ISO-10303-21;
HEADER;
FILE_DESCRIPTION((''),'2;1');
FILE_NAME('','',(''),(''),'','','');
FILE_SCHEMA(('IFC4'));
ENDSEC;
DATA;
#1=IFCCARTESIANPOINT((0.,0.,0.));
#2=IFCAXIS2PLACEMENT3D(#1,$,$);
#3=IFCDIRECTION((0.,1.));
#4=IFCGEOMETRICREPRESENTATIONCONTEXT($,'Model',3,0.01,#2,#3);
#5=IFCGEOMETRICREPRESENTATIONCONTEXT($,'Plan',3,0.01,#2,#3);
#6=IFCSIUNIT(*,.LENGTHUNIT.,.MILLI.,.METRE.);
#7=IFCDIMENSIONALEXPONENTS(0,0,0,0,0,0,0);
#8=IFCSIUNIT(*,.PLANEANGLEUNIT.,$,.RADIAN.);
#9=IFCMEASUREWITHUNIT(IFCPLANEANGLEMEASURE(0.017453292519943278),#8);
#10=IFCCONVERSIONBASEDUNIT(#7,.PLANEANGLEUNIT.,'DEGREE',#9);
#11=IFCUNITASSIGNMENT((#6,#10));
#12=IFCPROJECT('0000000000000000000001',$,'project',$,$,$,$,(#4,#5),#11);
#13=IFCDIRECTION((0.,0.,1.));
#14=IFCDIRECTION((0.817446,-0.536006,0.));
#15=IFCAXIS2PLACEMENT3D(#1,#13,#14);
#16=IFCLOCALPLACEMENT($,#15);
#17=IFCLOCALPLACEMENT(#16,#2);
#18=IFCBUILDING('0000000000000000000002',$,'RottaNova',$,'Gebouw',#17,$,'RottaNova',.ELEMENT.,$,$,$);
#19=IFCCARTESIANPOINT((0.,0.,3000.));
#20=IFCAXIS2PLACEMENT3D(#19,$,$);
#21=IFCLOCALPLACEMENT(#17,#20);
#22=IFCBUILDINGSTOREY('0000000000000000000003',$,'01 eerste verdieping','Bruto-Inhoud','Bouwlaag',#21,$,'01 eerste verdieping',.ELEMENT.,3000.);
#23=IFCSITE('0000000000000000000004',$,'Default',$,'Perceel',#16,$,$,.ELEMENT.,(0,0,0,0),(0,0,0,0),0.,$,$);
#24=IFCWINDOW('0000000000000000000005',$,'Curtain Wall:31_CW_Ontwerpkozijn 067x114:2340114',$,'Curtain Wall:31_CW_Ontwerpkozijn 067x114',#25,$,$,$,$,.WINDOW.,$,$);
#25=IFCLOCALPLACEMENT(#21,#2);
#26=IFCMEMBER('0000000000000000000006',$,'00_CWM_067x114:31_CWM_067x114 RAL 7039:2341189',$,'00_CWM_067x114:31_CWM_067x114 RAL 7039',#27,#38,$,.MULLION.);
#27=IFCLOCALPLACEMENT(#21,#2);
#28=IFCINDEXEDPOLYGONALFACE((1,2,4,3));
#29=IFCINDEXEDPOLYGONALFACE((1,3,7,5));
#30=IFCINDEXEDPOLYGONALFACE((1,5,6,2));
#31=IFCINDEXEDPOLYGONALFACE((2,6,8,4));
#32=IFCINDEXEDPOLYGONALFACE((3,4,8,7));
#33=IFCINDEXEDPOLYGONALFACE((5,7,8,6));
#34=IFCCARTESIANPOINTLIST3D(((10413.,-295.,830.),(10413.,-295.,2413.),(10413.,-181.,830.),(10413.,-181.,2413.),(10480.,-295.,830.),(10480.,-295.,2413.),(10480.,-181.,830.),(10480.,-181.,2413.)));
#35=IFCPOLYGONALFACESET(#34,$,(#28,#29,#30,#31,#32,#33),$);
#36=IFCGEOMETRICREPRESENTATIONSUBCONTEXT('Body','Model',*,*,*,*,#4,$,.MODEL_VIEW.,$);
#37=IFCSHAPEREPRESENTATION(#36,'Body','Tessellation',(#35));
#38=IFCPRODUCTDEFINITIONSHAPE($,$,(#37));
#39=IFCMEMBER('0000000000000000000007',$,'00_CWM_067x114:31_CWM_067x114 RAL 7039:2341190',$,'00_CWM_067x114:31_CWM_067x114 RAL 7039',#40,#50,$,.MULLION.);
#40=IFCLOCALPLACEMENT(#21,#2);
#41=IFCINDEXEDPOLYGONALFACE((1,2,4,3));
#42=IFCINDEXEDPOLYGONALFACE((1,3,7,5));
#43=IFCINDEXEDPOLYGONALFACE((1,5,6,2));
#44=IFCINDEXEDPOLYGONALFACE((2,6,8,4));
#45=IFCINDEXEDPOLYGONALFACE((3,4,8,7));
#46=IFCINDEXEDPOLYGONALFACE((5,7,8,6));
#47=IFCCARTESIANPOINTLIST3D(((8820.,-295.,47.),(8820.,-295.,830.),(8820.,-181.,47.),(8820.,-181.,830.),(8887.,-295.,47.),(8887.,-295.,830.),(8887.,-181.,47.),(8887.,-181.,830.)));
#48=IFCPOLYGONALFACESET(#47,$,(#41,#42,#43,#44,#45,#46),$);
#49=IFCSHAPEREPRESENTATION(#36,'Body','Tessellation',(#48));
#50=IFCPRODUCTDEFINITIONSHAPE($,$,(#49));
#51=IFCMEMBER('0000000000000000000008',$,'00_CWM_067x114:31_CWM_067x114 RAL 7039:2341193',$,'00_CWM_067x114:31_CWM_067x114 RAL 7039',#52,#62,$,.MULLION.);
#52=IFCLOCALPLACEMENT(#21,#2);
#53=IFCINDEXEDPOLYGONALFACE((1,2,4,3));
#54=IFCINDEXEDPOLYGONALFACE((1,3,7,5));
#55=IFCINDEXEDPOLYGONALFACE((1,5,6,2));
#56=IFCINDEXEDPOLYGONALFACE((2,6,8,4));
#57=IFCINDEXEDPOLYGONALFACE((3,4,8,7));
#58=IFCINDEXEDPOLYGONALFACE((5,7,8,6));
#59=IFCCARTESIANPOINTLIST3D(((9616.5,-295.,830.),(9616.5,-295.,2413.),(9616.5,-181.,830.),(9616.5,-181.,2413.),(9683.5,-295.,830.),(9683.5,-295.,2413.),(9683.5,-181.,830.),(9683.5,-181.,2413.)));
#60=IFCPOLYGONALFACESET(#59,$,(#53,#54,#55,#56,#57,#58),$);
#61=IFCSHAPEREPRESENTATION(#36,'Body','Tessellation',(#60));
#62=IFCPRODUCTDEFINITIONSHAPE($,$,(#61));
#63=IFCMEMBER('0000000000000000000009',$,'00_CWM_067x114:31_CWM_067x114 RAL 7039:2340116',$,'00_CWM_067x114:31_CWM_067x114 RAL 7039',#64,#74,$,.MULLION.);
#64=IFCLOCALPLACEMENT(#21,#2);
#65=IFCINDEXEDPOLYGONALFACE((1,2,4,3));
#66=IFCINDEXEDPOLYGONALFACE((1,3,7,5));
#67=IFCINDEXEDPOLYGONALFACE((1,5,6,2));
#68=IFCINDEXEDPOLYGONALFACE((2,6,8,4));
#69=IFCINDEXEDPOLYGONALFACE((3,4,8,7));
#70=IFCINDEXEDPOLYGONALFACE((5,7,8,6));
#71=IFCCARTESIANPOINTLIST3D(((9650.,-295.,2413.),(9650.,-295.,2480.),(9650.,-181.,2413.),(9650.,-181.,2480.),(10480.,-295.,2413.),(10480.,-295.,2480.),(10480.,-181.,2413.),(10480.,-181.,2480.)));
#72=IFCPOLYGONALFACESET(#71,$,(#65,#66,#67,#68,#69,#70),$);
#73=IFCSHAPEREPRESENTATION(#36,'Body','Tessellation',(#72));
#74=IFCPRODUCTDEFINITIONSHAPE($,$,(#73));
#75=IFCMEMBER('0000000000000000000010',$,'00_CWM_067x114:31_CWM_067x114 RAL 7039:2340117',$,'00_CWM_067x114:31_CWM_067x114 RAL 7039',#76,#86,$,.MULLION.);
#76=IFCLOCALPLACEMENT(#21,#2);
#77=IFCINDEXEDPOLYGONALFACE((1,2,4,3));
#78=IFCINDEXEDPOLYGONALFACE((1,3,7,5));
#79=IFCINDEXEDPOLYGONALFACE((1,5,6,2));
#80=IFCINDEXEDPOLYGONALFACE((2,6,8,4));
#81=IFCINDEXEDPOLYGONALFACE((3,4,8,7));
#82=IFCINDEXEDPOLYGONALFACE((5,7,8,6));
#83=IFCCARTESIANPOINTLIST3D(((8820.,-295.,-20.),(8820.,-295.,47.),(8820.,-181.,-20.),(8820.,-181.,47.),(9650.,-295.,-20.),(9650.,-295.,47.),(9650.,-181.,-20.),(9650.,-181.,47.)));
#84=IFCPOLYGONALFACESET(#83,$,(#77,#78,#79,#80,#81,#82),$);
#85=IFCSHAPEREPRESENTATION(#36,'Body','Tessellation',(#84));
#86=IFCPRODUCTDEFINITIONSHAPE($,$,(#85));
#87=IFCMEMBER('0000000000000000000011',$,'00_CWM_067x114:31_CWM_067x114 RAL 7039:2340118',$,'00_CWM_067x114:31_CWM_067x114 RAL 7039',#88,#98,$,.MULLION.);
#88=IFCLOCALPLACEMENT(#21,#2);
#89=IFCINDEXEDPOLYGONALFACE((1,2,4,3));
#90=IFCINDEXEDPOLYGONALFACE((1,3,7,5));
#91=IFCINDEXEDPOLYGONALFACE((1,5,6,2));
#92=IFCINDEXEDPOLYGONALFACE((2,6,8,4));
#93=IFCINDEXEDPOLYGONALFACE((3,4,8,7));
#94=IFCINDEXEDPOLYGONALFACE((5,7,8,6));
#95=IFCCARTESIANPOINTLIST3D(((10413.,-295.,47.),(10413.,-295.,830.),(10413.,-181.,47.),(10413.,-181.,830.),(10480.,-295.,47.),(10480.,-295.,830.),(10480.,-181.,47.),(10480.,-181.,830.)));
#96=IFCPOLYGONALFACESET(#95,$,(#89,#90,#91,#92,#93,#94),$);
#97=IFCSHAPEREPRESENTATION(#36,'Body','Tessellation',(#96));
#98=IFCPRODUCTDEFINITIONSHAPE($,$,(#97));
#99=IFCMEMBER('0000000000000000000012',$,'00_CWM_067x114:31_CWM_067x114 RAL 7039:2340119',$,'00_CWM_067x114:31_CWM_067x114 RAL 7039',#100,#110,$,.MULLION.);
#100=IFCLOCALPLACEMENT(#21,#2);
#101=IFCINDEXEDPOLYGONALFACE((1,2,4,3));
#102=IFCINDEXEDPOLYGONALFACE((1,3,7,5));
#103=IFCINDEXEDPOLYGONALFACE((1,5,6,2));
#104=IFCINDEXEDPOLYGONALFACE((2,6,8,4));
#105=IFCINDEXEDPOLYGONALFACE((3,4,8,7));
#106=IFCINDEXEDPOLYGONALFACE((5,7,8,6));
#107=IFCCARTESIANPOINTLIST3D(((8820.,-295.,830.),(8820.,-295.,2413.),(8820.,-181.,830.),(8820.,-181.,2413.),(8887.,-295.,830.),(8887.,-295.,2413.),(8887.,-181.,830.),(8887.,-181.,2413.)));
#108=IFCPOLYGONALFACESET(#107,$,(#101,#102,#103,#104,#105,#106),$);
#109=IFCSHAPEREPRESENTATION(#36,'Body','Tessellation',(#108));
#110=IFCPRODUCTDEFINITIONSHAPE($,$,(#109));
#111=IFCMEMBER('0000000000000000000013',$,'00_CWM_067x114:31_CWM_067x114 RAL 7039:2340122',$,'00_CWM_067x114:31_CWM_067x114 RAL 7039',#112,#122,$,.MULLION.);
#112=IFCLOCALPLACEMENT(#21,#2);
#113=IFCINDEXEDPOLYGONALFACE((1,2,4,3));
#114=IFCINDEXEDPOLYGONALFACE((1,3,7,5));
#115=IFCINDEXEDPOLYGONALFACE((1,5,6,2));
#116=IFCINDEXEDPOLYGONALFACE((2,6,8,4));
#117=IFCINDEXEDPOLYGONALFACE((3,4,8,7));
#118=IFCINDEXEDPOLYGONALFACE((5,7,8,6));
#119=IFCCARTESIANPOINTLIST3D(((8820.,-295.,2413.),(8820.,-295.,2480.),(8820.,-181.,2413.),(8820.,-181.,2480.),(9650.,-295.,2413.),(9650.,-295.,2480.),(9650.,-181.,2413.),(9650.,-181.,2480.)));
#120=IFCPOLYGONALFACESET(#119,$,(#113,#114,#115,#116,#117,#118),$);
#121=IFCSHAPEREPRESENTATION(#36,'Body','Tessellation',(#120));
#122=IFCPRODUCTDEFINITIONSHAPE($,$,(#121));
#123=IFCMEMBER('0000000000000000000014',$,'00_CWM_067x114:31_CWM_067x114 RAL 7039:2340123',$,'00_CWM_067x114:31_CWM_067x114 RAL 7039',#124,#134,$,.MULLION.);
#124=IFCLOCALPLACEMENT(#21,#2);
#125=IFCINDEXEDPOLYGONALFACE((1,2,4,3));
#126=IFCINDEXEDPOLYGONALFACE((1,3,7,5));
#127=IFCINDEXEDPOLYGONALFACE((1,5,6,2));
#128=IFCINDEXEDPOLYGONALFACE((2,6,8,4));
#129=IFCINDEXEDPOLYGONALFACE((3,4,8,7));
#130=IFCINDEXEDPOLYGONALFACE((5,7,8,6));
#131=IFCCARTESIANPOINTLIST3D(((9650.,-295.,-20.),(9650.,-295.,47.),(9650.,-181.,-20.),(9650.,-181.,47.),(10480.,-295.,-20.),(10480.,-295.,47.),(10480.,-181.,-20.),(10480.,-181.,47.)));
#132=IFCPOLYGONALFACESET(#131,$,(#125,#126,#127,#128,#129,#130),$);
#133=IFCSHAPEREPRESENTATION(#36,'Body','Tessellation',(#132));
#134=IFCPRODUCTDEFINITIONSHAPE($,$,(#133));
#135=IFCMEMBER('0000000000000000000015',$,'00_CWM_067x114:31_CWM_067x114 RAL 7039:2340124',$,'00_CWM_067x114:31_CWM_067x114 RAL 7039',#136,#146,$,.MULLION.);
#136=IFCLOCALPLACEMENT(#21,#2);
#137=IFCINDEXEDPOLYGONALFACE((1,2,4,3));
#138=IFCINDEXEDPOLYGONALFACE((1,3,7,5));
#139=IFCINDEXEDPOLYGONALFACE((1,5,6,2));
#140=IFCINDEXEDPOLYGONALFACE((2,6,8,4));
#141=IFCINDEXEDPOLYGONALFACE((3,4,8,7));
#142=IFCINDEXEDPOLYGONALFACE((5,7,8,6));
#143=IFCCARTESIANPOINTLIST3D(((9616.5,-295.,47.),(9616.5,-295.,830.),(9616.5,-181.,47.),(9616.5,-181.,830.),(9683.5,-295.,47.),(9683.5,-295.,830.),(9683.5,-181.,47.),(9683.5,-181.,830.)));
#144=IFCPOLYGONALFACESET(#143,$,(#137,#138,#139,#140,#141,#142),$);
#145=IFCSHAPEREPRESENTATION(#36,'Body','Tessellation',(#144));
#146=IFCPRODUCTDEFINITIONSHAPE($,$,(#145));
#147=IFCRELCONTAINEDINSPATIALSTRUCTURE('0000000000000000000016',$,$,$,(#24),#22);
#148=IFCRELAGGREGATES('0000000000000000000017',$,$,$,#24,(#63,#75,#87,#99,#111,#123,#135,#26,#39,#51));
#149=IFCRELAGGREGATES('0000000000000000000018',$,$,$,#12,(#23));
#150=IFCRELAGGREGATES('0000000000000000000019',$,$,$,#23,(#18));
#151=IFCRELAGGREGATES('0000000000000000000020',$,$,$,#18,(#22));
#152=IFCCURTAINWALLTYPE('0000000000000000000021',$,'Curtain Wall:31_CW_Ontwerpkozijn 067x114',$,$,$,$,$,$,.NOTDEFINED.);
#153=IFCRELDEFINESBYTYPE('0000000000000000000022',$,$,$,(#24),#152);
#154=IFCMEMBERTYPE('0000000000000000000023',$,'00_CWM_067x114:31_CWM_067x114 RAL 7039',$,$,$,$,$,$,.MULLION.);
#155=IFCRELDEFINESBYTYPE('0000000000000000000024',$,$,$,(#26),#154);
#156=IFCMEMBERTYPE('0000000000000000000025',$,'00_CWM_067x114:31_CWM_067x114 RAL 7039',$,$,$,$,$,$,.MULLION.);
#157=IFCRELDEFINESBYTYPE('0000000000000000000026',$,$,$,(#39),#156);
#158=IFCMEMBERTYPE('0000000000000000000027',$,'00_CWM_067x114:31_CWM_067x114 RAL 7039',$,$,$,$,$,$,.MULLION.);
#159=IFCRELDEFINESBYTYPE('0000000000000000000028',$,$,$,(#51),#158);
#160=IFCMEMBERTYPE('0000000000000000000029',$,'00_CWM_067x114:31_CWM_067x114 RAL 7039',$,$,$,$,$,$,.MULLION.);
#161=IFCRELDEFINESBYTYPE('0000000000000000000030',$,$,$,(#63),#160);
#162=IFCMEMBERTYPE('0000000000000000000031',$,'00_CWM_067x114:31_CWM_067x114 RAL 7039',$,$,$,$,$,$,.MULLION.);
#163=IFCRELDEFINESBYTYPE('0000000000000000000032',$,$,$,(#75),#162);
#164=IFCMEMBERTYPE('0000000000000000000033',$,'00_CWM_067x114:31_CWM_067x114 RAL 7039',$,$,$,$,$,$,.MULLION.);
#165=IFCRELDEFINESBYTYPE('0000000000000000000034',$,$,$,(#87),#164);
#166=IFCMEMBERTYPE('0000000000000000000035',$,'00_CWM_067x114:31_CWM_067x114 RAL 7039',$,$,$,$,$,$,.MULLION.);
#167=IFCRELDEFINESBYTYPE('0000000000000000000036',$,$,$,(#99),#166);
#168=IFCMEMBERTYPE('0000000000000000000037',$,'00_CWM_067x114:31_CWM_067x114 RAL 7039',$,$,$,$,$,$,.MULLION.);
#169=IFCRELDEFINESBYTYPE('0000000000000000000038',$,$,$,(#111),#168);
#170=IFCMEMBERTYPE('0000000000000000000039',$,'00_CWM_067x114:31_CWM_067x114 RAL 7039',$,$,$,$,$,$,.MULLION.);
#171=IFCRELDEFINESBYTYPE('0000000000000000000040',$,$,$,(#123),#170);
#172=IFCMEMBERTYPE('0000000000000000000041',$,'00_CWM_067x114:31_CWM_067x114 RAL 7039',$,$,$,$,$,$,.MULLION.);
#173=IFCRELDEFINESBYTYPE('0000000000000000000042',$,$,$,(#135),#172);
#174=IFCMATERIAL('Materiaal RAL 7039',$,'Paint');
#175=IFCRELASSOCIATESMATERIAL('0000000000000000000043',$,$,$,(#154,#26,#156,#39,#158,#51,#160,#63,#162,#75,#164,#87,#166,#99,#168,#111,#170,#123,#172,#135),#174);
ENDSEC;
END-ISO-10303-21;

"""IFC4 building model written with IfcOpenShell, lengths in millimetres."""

from ifc_helpers import new_model, entity, si_unit, converted_unit, direction, frame, origin, place, context, subcontext, project, spatial, indexed_curve, outline, extrude, source, transform, mapped, material, type_object, type_shapes, element, aggregate, save


model = new_model("IFC4")

# Units and contexts
model_context = context("Model", 3, precision=0.01, world=origin(), true_north=direction((0.0, 1.0)))
plan_context = context("Plan", 3, precision=0.01, world=origin(), true_north=direction((0.0, 1.0)))
body_context = subcontext(model_context, "Body", "Model", "MODEL_VIEW")
ifc_project = project(units=[si_unit("LENGTHUNIT", "METRE", prefix="MILLI"), converted_unit("PLANEANGLEUNIT", "DEGREE", entity("IfcPlaneAngleMeasure", 0.017453292519943278), si_unit("PLANEANGLEUNIT", "RADIAN"), dimensions=[0, 0, 0, 0, 0, 0, 0])], contexts=[model_context, plan_context])

# Site, building, storey
site_placement = place(None, frame((0.0, 0.0, 0.0), z_axis=(0.0, 0.0, 1.0), x_axis=(0.817446, -0.536006, 0.0)))
site = spatial("IfcSite", under=ifc_project, at=site_placement, Name="Default", ObjectType="Perceel", CompositionType="ELEMENT", RefLatitude=(0, 0, 0, 0), RefLongitude=(0, 0, 0, 0), RefElevation=0.0)
building_placement = place(site_placement, origin())
building = spatial("IfcBuilding", under=site, at=building_placement, Name="RottaNova", ObjectType="Gebouw", LongName="RottaNova", CompositionType="ELEMENT")
storey_placement = place(building_placement, frame((0.0, 0.0, 3000.0)))
storey = spatial("IfcBuildingStorey", under=building, at=storey_placement, Name="01 eerste verdieping", Description="Bruto-Inhoud", ObjectType="Bouwlaag", LongName="01 eerste verdieping", CompositionType="ELEMENT", Elevation=3000.0)

# Window, members
curtain_wall_type = type_object("IfcCurtainWallType", Name="Curtain Wall:31_CW_Ontwerpkozijn 067x114", PredefinedType="NOTDEFINED")
window_placement = place(storey_placement, frame((0.0, 0.0, -3000.0)))
window = element("IfcWindow", 1, at=window_placement, inside=storey, type_object=curtain_wall_type, Name="Curtain Wall:31_CW_Ontwerpkozijn 067x114:2340114", ObjectType="Curtain Wall:31_CW_Ontwerpkozijn 067x114", PredefinedType="WINDOW")
ifc_material_1 = material(Name="Materiaal RAL 7039", Category="Paint")
member_type_1 = type_object("IfcMemberType", Name="00_CWM_067x114:31_CWM_067x114 RAL 7039", PredefinedType="MULLION", material=ifc_material_1)
shared_shape_1 = source(origin(), body_context, "Body", "SweptSolid", [
    extrude(outline(indexed_curve([(-33.5, -57.0), (33.5, -57.0), (33.5, 57.0), (-33.5, 57.0), (-33.5, -57.0)], self_intersect=False)), frame((-33.5, 57.0, -1583.0), z_axis=(0.0, 0.0, 1.0), x_axis=(-1.0, 0.0, 0.0)), (0.0, 0.0, 1.0), 1583.0),
])
type_shapes(member_type_1, [shared_shape_1])
member_1_placement = place(window_placement, frame((10480.0, -181.0, 3830.0), z_axis=(0.0, 0.0, -1.0), x_axis=(1.0, 0.0, 0.0)))
member_1 = element("IfcMember", 2, at=member_1_placement, type_object=member_type_1, material=ifc_material_1, Name="00_CWM_067x114:31_CWM_067x114 RAL 7039:2341189", ObjectType="00_CWM_067x114:31_CWM_067x114 RAL 7039", PredefinedType="MULLION", context=body_context, shape_type="MappedRepresentation", body=[
    mapped(shared_shape_1, transform((0.0, 0.0, 0.0), scale=1.0)),
])
member_type_2 = type_object("IfcMemberType", Name="00_CWM_067x114:31_CWM_067x114 RAL 7039", PredefinedType="MULLION", material=ifc_material_1)
shared_shape_2 = source(origin(), body_context, "Body", "SweptSolid", [
    extrude(outline(indexed_curve([(-33.5, -57.0), (33.5, -57.0), (33.5, 57.0), (-33.5, 57.0), (-33.5, -57.0)], self_intersect=False)), frame((-33.5, 57.0, -783.0), z_axis=(0.0, 0.0, 1.0), x_axis=(-1.0, 0.0, 0.0)), (0.0, 0.0, 1.0), 783.0),
])
type_shapes(member_type_2, [shared_shape_2])
member_2_placement = place(window_placement, frame((8820.0, -181.0, 3830.0), z_axis=(0.0, 0.0, 1.0), x_axis=(-1.0, 0.0, 0.0)))
member_2 = element("IfcMember", 3, at=member_2_placement, type_object=member_type_2, material=ifc_material_1, Name="00_CWM_067x114:31_CWM_067x114 RAL 7039:2341190", ObjectType="00_CWM_067x114:31_CWM_067x114 RAL 7039", PredefinedType="MULLION", context=body_context, shape_type="MappedRepresentation", body=[
    mapped(shared_shape_2, transform((0.0, 0.0, 0.0), scale=1.0)),
])
member_type_3 = type_object("IfcMemberType", Name="00_CWM_067x114:31_CWM_067x114 RAL 7039", PredefinedType="MULLION", material=ifc_material_1)
shared_shape_3 = source(origin(), body_context, "Body", "SweptSolid", [
    extrude(outline(indexed_curve([(-33.5, -57.0), (33.5, -57.0), (33.5, 57.0), (-33.5, 57.0), (-33.5, -57.0)], self_intersect=False)), frame((0.0, 57.0, -1583.0), z_axis=(0.0, 0.0, 1.0), x_axis=(-1.0, 0.0, 0.0)), (0.0, 0.0, 1.0), 1583.0),
])
type_shapes(member_type_3, [shared_shape_3])
member_3_placement = place(window_placement, frame((9650.0, -181.0, 3830.0), z_axis=(0.0, 0.0, -1.0), x_axis=(1.0, 0.0, 0.0)))
member_3 = element("IfcMember", 4, at=member_3_placement, type_object=member_type_3, material=ifc_material_1, Name="00_CWM_067x114:31_CWM_067x114 RAL 7039:2341193", ObjectType="00_CWM_067x114:31_CWM_067x114 RAL 7039", PredefinedType="MULLION", context=body_context, shape_type="MappedRepresentation", body=[
    mapped(shared_shape_3, transform((0.0, 0.0, 0.0), scale=1.0)),
])
member_type_4 = type_object("IfcMemberType", Name="00_CWM_067x114:31_CWM_067x114 RAL 7039", PredefinedType="MULLION", material=ifc_material_1)
shared_shape_4 = source(origin(), body_context, "Body", "SweptSolid", [
    extrude(outline(indexed_curve([(-33.5, -57.0), (33.5, -57.0), (33.5, 57.0), (-33.5, 57.0), (-33.5, -57.0)], self_intersect=False)), frame((-33.5, 57.0, -830.0), z_axis=(0.0, 0.0, 1.0), x_axis=(-1.0, 0.0, 0.0)), (0.0, 0.0, 1.0), 830.0),
])
type_shapes(member_type_4, [shared_shape_4])
member_4_placement = place(window_placement, frame((10480.0, -181.0, 5480.0), z_axis=(1.0, 0.0, 0.0), x_axis=(0.0, 0.0, 1.0)))
member_4 = element("IfcMember", 5, at=member_4_placement, type_object=member_type_4, material=ifc_material_1, Name="00_CWM_067x114:31_CWM_067x114 RAL 7039:2340116", ObjectType="00_CWM_067x114:31_CWM_067x114 RAL 7039", PredefinedType="MULLION", context=body_context, shape_type="MappedRepresentation", body=[
    mapped(shared_shape_4, transform((0.0, 0.0, 0.0), scale=1.0)),
])
member_type_5 = type_object("IfcMemberType", Name="00_CWM_067x114:31_CWM_067x114 RAL 7039", PredefinedType="MULLION", material=ifc_material_1)
shared_shape_5 = source(origin(), body_context, "Body", "SweptSolid", [
    extrude(outline(indexed_curve([(-33.5, -57.0), (33.5, -57.0), (33.5, 57.0), (-33.5, 57.0), (-33.5, -57.0)], self_intersect=False)), frame((-33.5, 57.0, -830.0), z_axis=(0.0, 0.0, 1.0), x_axis=(-1.0, 0.0, 0.0)), (0.0, 0.0, 1.0), 830.0),
])
type_shapes(member_type_5, [shared_shape_5])
member_5_placement = place(window_placement, frame((8820.0, -181.0, 2980.0), z_axis=(-1.0, 0.0, 0.0), x_axis=(0.0, 0.0, -1.0)))
member_5 = element("IfcMember", 6, at=member_5_placement, type_object=member_type_5, material=ifc_material_1, Name="00_CWM_067x114:31_CWM_067x114 RAL 7039:2340117", ObjectType="00_CWM_067x114:31_CWM_067x114 RAL 7039", PredefinedType="MULLION", context=body_context, shape_type="MappedRepresentation", body=[
    mapped(shared_shape_5, transform((0.0, 0.0, 0.0), scale=1.0)),
])
member_type_6 = type_object("IfcMemberType", Name="00_CWM_067x114:31_CWM_067x114 RAL 7039", PredefinedType="MULLION", material=ifc_material_1)
shared_shape_6 = source(origin(), body_context, "Body", "SweptSolid", [
    extrude(outline(indexed_curve([(-33.5, -57.0), (33.5, -57.0), (33.5, 57.0), (-33.5, 57.0), (-33.5, -57.0)], self_intersect=False)), frame((-33.5, 57.0, -783.0), z_axis=(0.0, 0.0, 1.0), x_axis=(-1.0, 0.0, 0.0)), (0.0, 0.0, 1.0), 783.0),
])
type_shapes(member_type_6, [shared_shape_6])
member_6_placement = place(window_placement, frame((10480.0, -181.0, 3047.0), z_axis=(0.0, 0.0, -1.0), x_axis=(1.0, 0.0, 0.0)))
member_6 = element("IfcMember", 7, at=member_6_placement, type_object=member_type_6, material=ifc_material_1, Name="00_CWM_067x114:31_CWM_067x114 RAL 7039:2340118", ObjectType="00_CWM_067x114:31_CWM_067x114 RAL 7039", PredefinedType="MULLION", context=body_context, shape_type="MappedRepresentation", body=[
    mapped(shared_shape_6, transform((0.0, 0.0, 0.0), scale=1.0)),
])
member_type_7 = type_object("IfcMemberType", Name="00_CWM_067x114:31_CWM_067x114 RAL 7039", PredefinedType="MULLION", material=ifc_material_1)
shared_shape_7 = source(origin(), body_context, "Body", "SweptSolid", [
    extrude(outline(indexed_curve([(-33.5, -57.0), (33.5, -57.0), (33.5, 57.0), (-33.5, 57.0), (-33.5, -57.0)], self_intersect=False)), frame((-33.5, 57.0, -1583.0), z_axis=(0.0, 0.0, 1.0), x_axis=(-1.0, 0.0, 0.0)), (0.0, 0.0, 1.0), 1583.0),
])
type_shapes(member_type_7, [shared_shape_7])
member_7_placement = place(window_placement, frame((8820.0, -181.0, 5413.0), z_axis=(0.0, 0.0, 1.0), x_axis=(-1.0, 0.0, 0.0)))
member_7 = element("IfcMember", 8, at=member_7_placement, type_object=member_type_7, material=ifc_material_1, Name="00_CWM_067x114:31_CWM_067x114 RAL 7039:2340119", ObjectType="00_CWM_067x114:31_CWM_067x114 RAL 7039", PredefinedType="MULLION", context=body_context, shape_type="MappedRepresentation", body=[
    mapped(shared_shape_7, transform((0.0, 0.0, 0.0), scale=1.0)),
])
member_type_8 = type_object("IfcMemberType", Name="00_CWM_067x114:31_CWM_067x114 RAL 7039", PredefinedType="MULLION", material=ifc_material_1)
shared_shape_8 = source(origin(), body_context, "Body", "SweptSolid", [
    extrude(outline(indexed_curve([(-33.5, -57.0), (33.5, -57.0), (33.5, 57.0), (-33.5, 57.0), (-33.5, -57.0)], self_intersect=False)), frame((-33.5, 57.0, -830.0), z_axis=(0.0, 0.0, 1.0), x_axis=(-1.0, 0.0, 0.0)), (0.0, 0.0, 1.0), 830.0),
])
type_shapes(member_type_8, [shared_shape_8])
member_8_placement = place(window_placement, frame((9650.0, -181.0, 5480.0), z_axis=(1.0, 0.0, 0.0), x_axis=(0.0, 0.0, 1.0)))
member_8 = element("IfcMember", 9, at=member_8_placement, type_object=member_type_8, material=ifc_material_1, Name="00_CWM_067x114:31_CWM_067x114 RAL 7039:2340122", ObjectType="00_CWM_067x114:31_CWM_067x114 RAL 7039", PredefinedType="MULLION", context=body_context, shape_type="MappedRepresentation", body=[
    mapped(shared_shape_8, transform((0.0, 0.0, 0.0), scale=1.0)),
])
member_type_9 = type_object("IfcMemberType", Name="00_CWM_067x114:31_CWM_067x114 RAL 7039", PredefinedType="MULLION", material=ifc_material_1)
shared_shape_9 = source(origin(), body_context, "Body", "SweptSolid", [
    extrude(outline(indexed_curve([(-33.5, -57.0), (33.5, -57.0), (33.5, 57.0), (-33.5, 57.0), (-33.5, -57.0)], self_intersect=False)), frame((-33.5, 57.0, -830.0), z_axis=(0.0, 0.0, 1.0), x_axis=(-1.0, 0.0, 0.0)), (0.0, 0.0, 1.0), 830.0),
])
type_shapes(member_type_9, [shared_shape_9])
member_9_placement = place(window_placement, frame((9650.0, -181.0, 2980.0), z_axis=(-1.0, 0.0, 0.0), x_axis=(0.0, 0.0, -1.0)))
member_9 = element("IfcMember", 10, at=member_9_placement, type_object=member_type_9, material=ifc_material_1, Name="00_CWM_067x114:31_CWM_067x114 RAL 7039:2340123", ObjectType="00_CWM_067x114:31_CWM_067x114 RAL 7039", PredefinedType="MULLION", context=body_context, shape_type="MappedRepresentation", body=[
    mapped(shared_shape_9, transform((0.0, 0.0, 0.0), scale=1.0)),
])
member_type_10 = type_object("IfcMemberType", Name="00_CWM_067x114:31_CWM_067x114 RAL 7039", PredefinedType="MULLION", material=ifc_material_1)
shared_shape_10 = source(origin(), body_context, "Body", "SweptSolid", [
    extrude(outline(indexed_curve([(-33.5, -57.0), (33.5, -57.0), (33.5, 57.0), (-33.5, 57.0), (-33.5, -57.0)], self_intersect=False)), frame((0.0, 57.0, -783.0), z_axis=(0.0, 0.0, 1.0), x_axis=(-1.0, 0.0, 0.0)), (0.0, 0.0, 1.0), 783.0),
])
type_shapes(member_type_10, [shared_shape_10])
member_10_placement = place(window_placement, frame((9650.0, -181.0, 3047.0), z_axis=(0.0, 0.0, -1.0), x_axis=(1.0, 0.0, 0.0)))
member_10 = element("IfcMember", 11, at=member_10_placement, type_object=member_type_10, material=ifc_material_1, Name="00_CWM_067x114:31_CWM_067x114 RAL 7039:2340124", ObjectType="00_CWM_067x114:31_CWM_067x114 RAL 7039", PredefinedType="MULLION", context=body_context, shape_type="MappedRepresentation", body=[
    mapped(shared_shape_10, transform((0.0, 0.0, 0.0), scale=1.0)),
])
aggregate(window, [member_4, member_5, member_6, member_7, member_8, member_9, member_10, member_1, member_2, member_3])

save(model, "model.ifc")
